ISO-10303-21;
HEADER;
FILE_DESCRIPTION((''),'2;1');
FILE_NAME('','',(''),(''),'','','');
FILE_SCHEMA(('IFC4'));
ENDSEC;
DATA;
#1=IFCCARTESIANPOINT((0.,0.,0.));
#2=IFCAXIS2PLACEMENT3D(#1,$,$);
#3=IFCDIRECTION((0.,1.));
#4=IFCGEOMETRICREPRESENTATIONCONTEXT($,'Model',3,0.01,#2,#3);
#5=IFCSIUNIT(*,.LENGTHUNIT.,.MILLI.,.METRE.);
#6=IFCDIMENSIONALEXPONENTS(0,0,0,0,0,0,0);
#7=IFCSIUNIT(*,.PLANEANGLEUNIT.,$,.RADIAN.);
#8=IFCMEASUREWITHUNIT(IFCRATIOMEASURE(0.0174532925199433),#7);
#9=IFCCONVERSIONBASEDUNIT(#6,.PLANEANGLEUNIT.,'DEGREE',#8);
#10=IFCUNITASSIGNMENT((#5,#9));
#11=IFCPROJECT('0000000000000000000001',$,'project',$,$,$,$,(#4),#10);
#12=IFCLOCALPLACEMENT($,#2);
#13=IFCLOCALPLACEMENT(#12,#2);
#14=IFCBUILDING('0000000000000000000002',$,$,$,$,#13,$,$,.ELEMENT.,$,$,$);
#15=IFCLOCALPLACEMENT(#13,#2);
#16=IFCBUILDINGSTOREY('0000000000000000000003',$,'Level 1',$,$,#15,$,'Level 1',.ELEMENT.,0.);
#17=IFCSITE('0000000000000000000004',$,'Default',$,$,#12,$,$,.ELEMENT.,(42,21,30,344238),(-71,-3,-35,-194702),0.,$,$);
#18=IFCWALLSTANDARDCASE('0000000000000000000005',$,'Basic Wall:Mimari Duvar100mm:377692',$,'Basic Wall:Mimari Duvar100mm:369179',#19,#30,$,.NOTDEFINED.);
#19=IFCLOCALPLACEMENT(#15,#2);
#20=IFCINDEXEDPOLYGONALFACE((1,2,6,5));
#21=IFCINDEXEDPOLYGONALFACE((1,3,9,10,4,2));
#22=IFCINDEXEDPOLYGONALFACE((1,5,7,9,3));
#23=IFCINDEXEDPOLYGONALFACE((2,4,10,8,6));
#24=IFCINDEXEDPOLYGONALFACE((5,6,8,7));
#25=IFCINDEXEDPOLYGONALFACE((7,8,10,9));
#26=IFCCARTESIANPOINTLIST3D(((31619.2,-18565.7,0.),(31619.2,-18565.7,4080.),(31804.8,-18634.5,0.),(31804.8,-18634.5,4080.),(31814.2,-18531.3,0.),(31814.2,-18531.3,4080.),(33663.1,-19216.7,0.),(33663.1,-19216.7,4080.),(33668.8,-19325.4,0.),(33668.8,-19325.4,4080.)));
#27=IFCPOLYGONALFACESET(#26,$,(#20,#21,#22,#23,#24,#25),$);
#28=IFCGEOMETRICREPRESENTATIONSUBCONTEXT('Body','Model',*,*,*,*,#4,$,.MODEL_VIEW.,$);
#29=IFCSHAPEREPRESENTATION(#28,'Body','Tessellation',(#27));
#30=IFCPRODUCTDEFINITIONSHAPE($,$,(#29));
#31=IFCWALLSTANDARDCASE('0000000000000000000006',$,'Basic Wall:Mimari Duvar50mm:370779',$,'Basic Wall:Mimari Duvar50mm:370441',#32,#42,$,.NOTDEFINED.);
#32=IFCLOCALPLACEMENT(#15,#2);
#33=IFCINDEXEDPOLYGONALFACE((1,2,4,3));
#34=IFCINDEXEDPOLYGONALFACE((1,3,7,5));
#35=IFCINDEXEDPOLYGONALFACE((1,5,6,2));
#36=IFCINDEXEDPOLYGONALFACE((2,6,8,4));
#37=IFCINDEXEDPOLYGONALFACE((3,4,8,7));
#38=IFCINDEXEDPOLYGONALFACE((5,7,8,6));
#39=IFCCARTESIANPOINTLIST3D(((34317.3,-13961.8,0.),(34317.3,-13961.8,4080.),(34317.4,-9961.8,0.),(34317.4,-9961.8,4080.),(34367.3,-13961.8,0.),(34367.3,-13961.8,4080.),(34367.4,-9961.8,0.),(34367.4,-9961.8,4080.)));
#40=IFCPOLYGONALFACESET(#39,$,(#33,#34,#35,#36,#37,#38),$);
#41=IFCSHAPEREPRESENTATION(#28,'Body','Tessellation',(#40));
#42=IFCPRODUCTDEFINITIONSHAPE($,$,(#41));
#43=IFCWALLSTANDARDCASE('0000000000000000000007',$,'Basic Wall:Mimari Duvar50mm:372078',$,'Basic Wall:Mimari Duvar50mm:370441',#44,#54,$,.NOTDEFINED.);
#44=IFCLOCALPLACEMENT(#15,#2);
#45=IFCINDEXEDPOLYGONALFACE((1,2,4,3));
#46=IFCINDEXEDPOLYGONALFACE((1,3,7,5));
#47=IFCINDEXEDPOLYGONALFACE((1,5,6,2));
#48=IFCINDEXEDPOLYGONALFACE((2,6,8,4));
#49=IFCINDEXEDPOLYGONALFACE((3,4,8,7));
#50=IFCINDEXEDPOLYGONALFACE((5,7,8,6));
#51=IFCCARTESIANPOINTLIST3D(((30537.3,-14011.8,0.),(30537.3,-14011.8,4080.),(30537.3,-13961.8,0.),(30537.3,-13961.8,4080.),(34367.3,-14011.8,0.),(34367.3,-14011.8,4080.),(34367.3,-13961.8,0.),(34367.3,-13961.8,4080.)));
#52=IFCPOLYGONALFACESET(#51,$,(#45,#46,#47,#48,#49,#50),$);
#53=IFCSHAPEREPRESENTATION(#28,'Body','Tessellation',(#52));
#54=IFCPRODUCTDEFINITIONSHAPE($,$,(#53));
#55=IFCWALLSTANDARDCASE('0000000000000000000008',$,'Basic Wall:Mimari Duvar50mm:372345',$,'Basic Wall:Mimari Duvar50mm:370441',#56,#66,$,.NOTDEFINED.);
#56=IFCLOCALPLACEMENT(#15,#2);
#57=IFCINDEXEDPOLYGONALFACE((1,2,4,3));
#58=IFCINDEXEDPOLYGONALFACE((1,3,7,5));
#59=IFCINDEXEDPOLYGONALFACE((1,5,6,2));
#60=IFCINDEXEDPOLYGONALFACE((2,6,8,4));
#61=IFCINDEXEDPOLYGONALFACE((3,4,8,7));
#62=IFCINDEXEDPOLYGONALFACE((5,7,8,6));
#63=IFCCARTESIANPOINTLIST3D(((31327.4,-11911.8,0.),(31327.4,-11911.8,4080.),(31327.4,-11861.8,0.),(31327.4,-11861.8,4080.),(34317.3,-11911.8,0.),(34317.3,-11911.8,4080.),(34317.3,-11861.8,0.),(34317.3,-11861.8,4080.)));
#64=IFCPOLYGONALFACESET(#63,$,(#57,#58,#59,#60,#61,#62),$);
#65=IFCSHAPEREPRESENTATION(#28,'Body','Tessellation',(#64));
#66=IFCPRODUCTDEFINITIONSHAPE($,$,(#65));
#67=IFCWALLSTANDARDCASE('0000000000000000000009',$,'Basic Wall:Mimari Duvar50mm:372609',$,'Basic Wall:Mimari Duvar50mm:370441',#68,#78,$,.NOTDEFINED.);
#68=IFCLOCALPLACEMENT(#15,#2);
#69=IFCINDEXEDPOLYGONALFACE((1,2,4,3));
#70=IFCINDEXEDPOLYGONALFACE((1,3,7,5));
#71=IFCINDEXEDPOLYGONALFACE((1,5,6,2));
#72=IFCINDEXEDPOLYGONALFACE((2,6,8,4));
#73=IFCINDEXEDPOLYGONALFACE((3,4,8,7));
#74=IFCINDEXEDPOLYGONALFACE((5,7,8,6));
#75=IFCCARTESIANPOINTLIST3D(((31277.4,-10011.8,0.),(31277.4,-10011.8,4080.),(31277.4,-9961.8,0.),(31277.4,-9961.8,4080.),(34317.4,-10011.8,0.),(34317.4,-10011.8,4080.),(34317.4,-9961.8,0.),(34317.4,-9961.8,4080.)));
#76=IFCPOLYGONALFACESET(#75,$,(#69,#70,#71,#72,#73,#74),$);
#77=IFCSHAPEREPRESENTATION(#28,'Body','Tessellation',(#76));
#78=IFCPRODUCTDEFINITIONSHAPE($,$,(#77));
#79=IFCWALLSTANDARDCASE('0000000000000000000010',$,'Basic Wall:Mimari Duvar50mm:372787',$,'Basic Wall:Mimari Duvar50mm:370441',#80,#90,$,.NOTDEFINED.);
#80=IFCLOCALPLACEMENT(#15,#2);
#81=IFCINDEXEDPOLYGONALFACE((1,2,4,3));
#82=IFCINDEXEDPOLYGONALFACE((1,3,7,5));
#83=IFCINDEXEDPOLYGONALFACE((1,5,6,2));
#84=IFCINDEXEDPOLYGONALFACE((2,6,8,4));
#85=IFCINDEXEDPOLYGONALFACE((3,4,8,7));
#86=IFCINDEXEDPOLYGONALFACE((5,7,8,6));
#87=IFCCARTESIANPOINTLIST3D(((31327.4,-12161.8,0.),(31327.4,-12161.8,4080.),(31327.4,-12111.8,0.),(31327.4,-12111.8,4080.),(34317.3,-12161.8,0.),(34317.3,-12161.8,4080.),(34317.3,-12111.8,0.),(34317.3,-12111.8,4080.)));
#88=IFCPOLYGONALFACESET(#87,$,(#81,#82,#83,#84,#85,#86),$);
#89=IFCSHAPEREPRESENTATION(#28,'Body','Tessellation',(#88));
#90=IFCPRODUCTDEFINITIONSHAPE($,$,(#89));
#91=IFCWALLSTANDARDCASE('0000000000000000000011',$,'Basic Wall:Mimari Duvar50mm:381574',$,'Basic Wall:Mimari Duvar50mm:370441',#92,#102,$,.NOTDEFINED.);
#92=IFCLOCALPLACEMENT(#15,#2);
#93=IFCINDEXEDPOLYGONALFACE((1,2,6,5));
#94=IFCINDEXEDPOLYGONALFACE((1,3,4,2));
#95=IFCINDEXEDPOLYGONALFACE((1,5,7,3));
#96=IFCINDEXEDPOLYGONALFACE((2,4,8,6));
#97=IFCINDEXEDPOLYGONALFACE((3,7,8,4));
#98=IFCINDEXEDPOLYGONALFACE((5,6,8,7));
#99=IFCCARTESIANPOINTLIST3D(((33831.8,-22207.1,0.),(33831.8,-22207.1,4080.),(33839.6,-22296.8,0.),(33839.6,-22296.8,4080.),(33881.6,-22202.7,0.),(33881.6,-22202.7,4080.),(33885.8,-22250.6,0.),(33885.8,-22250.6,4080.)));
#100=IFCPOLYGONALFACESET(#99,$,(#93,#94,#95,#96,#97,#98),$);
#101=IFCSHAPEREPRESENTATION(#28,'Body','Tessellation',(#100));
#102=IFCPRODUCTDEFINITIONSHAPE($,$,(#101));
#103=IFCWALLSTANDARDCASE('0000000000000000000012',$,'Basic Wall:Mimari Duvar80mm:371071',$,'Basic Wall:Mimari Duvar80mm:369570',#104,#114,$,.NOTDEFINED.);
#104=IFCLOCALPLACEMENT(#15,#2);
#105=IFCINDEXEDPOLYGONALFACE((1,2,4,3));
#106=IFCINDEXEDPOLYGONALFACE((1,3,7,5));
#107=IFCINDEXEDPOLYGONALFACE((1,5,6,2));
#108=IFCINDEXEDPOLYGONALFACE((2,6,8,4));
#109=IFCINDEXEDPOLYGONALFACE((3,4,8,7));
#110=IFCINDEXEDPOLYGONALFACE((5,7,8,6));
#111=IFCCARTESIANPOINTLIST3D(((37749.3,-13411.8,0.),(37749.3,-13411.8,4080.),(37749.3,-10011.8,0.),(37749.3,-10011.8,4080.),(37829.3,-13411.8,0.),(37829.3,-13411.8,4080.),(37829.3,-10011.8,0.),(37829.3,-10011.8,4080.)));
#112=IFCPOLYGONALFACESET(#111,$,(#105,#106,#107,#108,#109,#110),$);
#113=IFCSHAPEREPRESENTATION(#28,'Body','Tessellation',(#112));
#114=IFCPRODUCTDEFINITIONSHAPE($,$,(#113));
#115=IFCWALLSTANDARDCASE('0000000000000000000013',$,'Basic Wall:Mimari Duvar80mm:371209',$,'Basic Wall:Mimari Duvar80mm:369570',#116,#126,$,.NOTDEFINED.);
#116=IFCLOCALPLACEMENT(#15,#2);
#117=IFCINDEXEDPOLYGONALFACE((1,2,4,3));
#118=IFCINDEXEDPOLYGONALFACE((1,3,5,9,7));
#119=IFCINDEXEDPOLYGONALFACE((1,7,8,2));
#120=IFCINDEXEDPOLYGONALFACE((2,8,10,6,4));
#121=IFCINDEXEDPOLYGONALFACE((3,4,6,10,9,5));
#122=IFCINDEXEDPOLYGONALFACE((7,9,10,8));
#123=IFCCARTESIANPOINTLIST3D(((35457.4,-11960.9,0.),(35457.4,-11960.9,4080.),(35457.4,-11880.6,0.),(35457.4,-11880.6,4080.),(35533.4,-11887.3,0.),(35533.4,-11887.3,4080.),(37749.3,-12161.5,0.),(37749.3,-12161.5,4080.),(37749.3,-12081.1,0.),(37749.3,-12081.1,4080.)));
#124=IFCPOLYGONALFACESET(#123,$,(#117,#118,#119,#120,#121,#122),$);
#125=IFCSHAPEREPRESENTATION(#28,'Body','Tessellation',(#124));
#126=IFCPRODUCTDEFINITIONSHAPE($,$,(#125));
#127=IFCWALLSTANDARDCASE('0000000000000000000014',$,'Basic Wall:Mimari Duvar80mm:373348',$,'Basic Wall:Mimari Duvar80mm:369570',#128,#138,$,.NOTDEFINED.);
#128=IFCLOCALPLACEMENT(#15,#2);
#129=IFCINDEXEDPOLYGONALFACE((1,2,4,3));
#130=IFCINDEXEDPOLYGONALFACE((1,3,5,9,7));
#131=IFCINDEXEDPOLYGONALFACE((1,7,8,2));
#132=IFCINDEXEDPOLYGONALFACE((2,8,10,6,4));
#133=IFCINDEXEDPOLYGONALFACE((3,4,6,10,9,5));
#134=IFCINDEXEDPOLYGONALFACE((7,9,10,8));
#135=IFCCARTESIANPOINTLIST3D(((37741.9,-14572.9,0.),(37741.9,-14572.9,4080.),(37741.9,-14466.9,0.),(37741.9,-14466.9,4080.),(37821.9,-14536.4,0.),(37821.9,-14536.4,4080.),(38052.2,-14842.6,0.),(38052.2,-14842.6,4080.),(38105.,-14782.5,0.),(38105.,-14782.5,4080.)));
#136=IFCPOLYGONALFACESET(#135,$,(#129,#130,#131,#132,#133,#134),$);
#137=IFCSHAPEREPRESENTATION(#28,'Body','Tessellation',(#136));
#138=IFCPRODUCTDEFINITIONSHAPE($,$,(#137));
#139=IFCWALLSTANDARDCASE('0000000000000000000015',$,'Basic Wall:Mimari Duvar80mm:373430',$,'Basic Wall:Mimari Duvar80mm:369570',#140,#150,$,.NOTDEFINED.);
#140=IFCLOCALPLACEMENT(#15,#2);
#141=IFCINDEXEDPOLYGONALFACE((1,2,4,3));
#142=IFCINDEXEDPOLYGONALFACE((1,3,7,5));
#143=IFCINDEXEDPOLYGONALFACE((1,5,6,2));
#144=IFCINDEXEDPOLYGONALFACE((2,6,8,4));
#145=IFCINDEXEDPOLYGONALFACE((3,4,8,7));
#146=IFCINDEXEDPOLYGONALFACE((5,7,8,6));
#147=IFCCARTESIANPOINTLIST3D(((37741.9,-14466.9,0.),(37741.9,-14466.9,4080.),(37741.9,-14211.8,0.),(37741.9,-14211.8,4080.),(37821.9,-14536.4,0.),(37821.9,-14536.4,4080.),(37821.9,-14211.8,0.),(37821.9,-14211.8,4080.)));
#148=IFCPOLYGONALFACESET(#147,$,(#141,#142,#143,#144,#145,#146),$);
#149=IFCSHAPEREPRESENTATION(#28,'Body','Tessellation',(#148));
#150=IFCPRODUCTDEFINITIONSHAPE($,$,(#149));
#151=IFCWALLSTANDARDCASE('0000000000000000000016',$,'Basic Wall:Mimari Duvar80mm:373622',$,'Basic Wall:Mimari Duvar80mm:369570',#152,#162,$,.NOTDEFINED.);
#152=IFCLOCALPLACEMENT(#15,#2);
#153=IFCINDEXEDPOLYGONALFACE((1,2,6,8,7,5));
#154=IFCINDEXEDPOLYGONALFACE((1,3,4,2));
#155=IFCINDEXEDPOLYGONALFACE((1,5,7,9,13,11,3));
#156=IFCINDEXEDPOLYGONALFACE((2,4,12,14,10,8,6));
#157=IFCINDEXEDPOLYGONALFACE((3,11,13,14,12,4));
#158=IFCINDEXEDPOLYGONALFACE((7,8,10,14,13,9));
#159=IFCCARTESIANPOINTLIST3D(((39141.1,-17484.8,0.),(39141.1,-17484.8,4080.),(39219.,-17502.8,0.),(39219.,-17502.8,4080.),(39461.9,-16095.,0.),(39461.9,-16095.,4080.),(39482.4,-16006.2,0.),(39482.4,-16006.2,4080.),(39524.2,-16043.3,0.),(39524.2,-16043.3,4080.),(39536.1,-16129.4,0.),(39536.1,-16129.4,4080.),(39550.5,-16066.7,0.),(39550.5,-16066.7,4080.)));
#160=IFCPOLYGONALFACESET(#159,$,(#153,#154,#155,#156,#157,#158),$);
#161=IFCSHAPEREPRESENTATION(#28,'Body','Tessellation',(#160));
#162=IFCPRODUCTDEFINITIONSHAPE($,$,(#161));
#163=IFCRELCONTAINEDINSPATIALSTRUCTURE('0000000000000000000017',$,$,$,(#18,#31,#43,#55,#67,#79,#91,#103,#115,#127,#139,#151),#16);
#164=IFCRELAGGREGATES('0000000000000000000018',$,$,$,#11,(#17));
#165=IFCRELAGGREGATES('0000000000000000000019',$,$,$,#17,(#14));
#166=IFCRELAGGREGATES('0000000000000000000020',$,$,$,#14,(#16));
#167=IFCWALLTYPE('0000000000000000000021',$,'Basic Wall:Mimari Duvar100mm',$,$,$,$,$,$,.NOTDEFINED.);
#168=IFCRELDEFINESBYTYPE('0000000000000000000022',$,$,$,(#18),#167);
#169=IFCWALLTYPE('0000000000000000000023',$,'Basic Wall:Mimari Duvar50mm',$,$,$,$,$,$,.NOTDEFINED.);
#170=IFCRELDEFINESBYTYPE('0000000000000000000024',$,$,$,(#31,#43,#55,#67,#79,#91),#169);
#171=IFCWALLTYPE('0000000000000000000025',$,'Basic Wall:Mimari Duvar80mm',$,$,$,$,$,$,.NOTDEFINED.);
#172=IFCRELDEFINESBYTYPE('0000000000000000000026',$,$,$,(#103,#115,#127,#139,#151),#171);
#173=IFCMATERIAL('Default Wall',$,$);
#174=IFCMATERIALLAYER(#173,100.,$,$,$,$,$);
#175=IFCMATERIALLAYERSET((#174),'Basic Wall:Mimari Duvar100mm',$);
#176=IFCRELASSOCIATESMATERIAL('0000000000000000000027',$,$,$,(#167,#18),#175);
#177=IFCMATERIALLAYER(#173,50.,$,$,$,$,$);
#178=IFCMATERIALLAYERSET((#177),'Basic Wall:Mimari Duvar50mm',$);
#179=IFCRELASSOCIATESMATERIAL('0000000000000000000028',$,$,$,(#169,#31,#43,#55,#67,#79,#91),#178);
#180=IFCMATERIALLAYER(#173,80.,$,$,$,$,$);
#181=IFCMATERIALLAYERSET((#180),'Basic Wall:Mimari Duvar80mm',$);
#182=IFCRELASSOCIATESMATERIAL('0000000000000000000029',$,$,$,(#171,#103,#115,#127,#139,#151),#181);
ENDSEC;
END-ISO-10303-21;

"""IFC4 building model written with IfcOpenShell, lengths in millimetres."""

from ifc_helpers import new_model, entity, si_unit, converted_unit, direction, frame, frame_2d, origin, place, context, subcontext, project, spatial, polyline, rectangle, outline, extrude, material, layer, layer_set, layer_usage, type_object, element, save


model = new_model("IFC4")

# Units and contexts
model_context = context("Model", 3, precision=0.01, world=origin(), true_north=direction((0.0, 1.0)))
body_context = subcontext(model_context, "Body", "Model", "MODEL_VIEW")
ifc_project = project(units=[si_unit("LENGTHUNIT", "METRE", prefix="MILLI"), converted_unit("PLANEANGLEUNIT", "DEGREE", entity("IfcRatioMeasure", 0.0174532925199433), si_unit("PLANEANGLEUNIT", "RADIAN"), dimensions=[0, 0, 0, 0, 0, 0, 0])], contexts=[model_context])

# Site, building, storey
site_placement = place(None, origin())
site = spatial("IfcSite", under=ifc_project, at=site_placement, Name="Default", CompositionType="ELEMENT", RefLatitude=(42, 21, 30, 344238), RefLongitude=(-71, -3, -35, -194702), RefElevation=0.0)
building_placement = place(site_placement, origin())
building = spatial("IfcBuilding", under=site, at=building_placement, CompositionType="ELEMENT")
storey_placement = place(building_placement, origin())
storey = spatial("IfcBuildingStorey", under=building, at=storey_placement, Name="Level 1", LongName="Level 1", CompositionType="ELEMENT", Elevation=0.0)

# Walls
ifc_material_1 = material(Name="Default Wall")
ifc_layer_1 = layer(ifc_material_1, 100.0)
ifc_layer_set_1 = layer_set([ifc_layer_1], Name="Basic Wall:Mimari Duvar100mm")
ifc_layer_usage_1 = layer_usage(ifc_layer_set_1, "AXIS2", "NEGATIVE", 50.0)
wall_type_1 = type_object("IfcWallType", Name="Basic Wall:Mimari Duvar100mm", PredefinedType="NOTDEFINED", material=ifc_layer_set_1)
wall_1_placement = place(storey_placement, frame((33686.2, -19278.6, 0.0), z_axis=(0.0, 0.0, 1.0), x_axis=(-0.937659, 0.347558, 0.0)))
element("IfcWallStandardCase", 1, at=wall_1_placement, inside=storey, type_object=wall_type_1, material=ifc_layer_usage_1, Name="Basic Wall:Mimari Duvar100mm:377692", ObjectType="Basic Wall:Mimari Duvar100mm:369179", PredefinedType="NOTDEFINED", context=body_context, shape_type="SweptSolid", body=[
    extrude(outline(polyline([(2015.0, -50.0), (2185.9, 50.0), (1987.9, 50.0), (0.0, 50.0), (43.1, -50.0), (2015.0, -50.0)])), origin(), (0.0, 0.0, 1.0), 4080.0),
])
ifc_layer_2 = layer(ifc_material_1, 50.0)
ifc_layer_set_2 = layer_set([ifc_layer_2], Name="Basic Wall:Mimari Duvar50mm")
ifc_layer_usage_2 = layer_usage(ifc_layer_set_2, "AXIS2", "NEGATIVE", 25.0)
wall_type_2 = type_object("IfcWallType", Name="Basic Wall:Mimari Duvar50mm", PredefinedType="NOTDEFINED", material=ifc_layer_set_2)
wall_2_placement = place(storey_placement, frame((34342.3, -13961.8, 0.0), z_axis=(0.0, 0.0, 1.0), x_axis=(0.000009, 1.0, 0.0)))
element("IfcWallStandardCase", 2, at=wall_2_placement, inside=storey, type_object=wall_type_2, material=ifc_layer_usage_2, Name="Basic Wall:Mimari Duvar50mm:370779", ObjectType="Basic Wall:Mimari Duvar50mm:370441", PredefinedType="NOTDEFINED", context=body_context, shape_type="SweptSolid", body=[
    extrude(rectangle(XDim=4000.0, YDim=50.0, at=frame_2d((2000.0, 0.0), x_axis=(-1.0, 0.0))), origin(), (0.0, 0.0, 1.0), 4080.0),
])
ifc_layer_usage_3 = layer_usage(ifc_layer_set_2, "AXIS2", "NEGATIVE", 25.0)
wall_3_placement = place(storey_placement, frame((34367.3, -13986.8, 0.0), z_axis=(0.0, 0.0, 1.0), x_axis=(-1.0, 0.0, 0.0)))
element("IfcWallStandardCase", 3, at=wall_3_placement, inside=storey, type_object=wall_type_2, material=ifc_layer_usage_3, Name="Basic Wall:Mimari Duvar50mm:372078", ObjectType="Basic Wall:Mimari Duvar50mm:370441", PredefinedType="NOTDEFINED", context=body_context, shape_type="SweptSolid", body=[
    extrude(rectangle(XDim=3830.0, YDim=50.0, at=frame_2d((1915.0, 0.0), x_axis=(-1.0, 0.0))), origin(), (0.0, 0.0, 1.0), 4080.0),
])
ifc_layer_usage_4 = layer_usage(ifc_layer_set_2, "AXIS2", "NEGATIVE", 25.0)
wall_4_placement = place(storey_placement, frame((34317.3, -11886.8, 0.0), z_axis=(0.0, 0.0, 1.0), x_axis=(-1.0, 0.0, 0.0)))
element("IfcWallStandardCase", 4, at=wall_4_placement, inside=storey, type_object=wall_type_2, material=ifc_layer_usage_4, Name="Basic Wall:Mimari Duvar50mm:372345", ObjectType="Basic Wall:Mimari Duvar50mm:370441", PredefinedType="NOTDEFINED", context=body_context, shape_type="SweptSolid", body=[
    extrude(rectangle(XDim=2990.0, YDim=50.0, at=frame_2d((1495.0, 0.0), x_axis=(-1.0, 0.0))), origin(), (0.0, 0.0, 1.0), 4080.0),
])
ifc_layer_usage_5 = layer_usage(ifc_layer_set_2, "AXIS2", "NEGATIVE", 25.0)
wall_5_placement = place(storey_placement, frame((34317.4, -9986.8, 0.0), z_axis=(0.0, 0.0, 1.0), x_axis=(-1.0, 0.0, 0.0)))
element("IfcWallStandardCase", 5, at=wall_5_placement, inside=storey, type_object=wall_type_2, material=ifc_layer_usage_5, Name="Basic Wall:Mimari Duvar50mm:372609", ObjectType="Basic Wall:Mimari Duvar50mm:370441", PredefinedType="NOTDEFINED", context=body_context, shape_type="SweptSolid", body=[
    extrude(rectangle(XDim=3040.0, YDim=50.0, at=frame_2d((1520.0, 0.0), x_axis=(-1.0, 0.0))), origin(), (0.0, 0.0, 1.0), 4080.0),
])
ifc_layer_usage_6 = layer_usage(ifc_layer_set_2, "AXIS2", "NEGATIVE", 25.0)
wall_6_placement = place(storey_placement, frame((34317.3, -12136.8, 0.0), z_axis=(0.0, 0.0, 1.0), x_axis=(-1.0, 0.0, 0.0)))
element("IfcWallStandardCase", 6, at=wall_6_placement, inside=storey, type_object=wall_type_2, material=ifc_layer_usage_6, Name="Basic Wall:Mimari Duvar50mm:372787", ObjectType="Basic Wall:Mimari Duvar50mm:370441", PredefinedType="NOTDEFINED", context=body_context, shape_type="SweptSolid", body=[
    extrude(rectangle(XDim=2990.0, YDim=50.0, at=frame_2d((1495.0, 0.0), x_axis=(-1.0, 0.0))), origin(), (0.0, 0.0, 1.0), 4080.0),
])
ifc_layer_usage_7 = layer_usage(ifc_layer_set_2, "AXIS2", "NEGATIVE", 25.0)
wall_7_placement = place(storey_placement, frame((33864.6, -22294.6, 0.0), z_axis=(0.0, 0.0, 1.0), x_axis=(-0.087156, 0.996195, 0.0)))
element("IfcWallStandardCase", 7, at=wall_7_placement, inside=storey, type_object=wall_type_2, material=ifc_layer_usage_7, Name="Basic Wall:Mimari Duvar50mm:381574", ObjectType="Basic Wall:Mimari Duvar50mm:370441", PredefinedType="NOTDEFINED", context=body_context, shape_type="SweptSolid", body=[
    extrude(outline(polyline([(90.0, -25.0), (90.0, 25.0), (0.0, 25.0), (42.0, -25.0), (90.0, -25.0)])), origin(), (0.0, 0.0, 1.0), 4080.0),
])
ifc_layer_3 = layer(ifc_material_1, 80.0)
ifc_layer_set_3 = layer_set([ifc_layer_3], Name="Basic Wall:Mimari Duvar80mm")
ifc_layer_usage_8 = layer_usage(ifc_layer_set_3, "AXIS2", "NEGATIVE", 40.0)
wall_type_3 = type_object("IfcWallType", Name="Basic Wall:Mimari Duvar80mm", PredefinedType="NOTDEFINED", material=ifc_layer_set_3)
wall_8_placement = place(storey_placement, frame((37789.3, -13411.8, 0.0), z_axis=(0.0, 0.0, 1.0), x_axis=(0.0, 1.0, 0.0)))
element("IfcWallStandardCase", 8, at=wall_8_placement, inside=storey, type_object=wall_type_3, material=ifc_layer_usage_8, Name="Basic Wall:Mimari Duvar80mm:371071", ObjectType="Basic Wall:Mimari Duvar80mm:369570", PredefinedType="NOTDEFINED", context=body_context, shape_type="SweptSolid", body=[
    extrude(rectangle(XDim=3400.0, YDim=80.0, at=frame_2d((1700.0, 0.0), x_axis=(-1.0, 0.0))), origin(), (0.0, 0.0, 1.0), 4080.0),
])
ifc_layer_usage_9 = layer_usage(ifc_layer_set_3, "AXIS2", "NEGATIVE", 40.0)
wall_9_placement = place(storey_placement, frame((37752.8, -12121.6, 0.0), z_axis=(0.0, 0.0, 1.0), x_axis=(-0.996195, 0.087156, 0.0)))
element("IfcWallStandardCase", 9, at=wall_9_placement, inside=storey, type_object=wall_type_3, material=ifc_layer_usage_9, Name="Basic Wall:Mimari Duvar80mm:371209", ObjectType="Basic Wall:Mimari Duvar80mm:369570", PredefinedType="NOTDEFINED", context=body_context, shape_type="SweptSolid", body=[
    extrude(outline(polyline([(2307.6, -40.0), (2300.6, 40.0), (0.0, 40.0), (7.0, -40.0), (2231.3, -40.0), (2307.6, -40.0)])), origin(), (0.0, 0.0, 1.0), 4080.0),
])
ifc_layer_usage_10 = layer_usage(ifc_layer_set_3, "AXIS2", "NEGATIVE", 40.0)
wall_10_placement = place(storey_placement, frame((38078.7, -14812.6, 0.0), z_axis=(0.0, 0.0, 1.0), x_axis=(-0.75471, 0.656059, 0.0)))
element("IfcWallStandardCase", 10, at=wall_10_placement, inside=storey, type_object=wall_type_3, material=ifc_layer_usage_10, Name="Basic Wall:Mimari Duvar80mm:373348", ObjectType="Basic Wall:Mimari Duvar80mm:369570", PredefinedType="NOTDEFINED", context=body_context, shape_type="SweptSolid", body=[
    extrude(outline(polyline([(481.0, -40.0), (411.5, 40.0), (0.4, 40.0), (0.0, -40.0), (375.0, -40.0), (481.0, -40.0)])), origin(), (0.0, 0.0, 1.0), 4080.0),
])
ifc_layer_usage_11 = layer_usage(ifc_layer_set_3, "AXIS2", "NEGATIVE", 40.0)
wall_11_placement = place(storey_placement, frame((37781.9, -14536.4, 0.0), z_axis=(0.0, 0.0, 1.0), x_axis=(0.0, 1.0, 0.0)))
element("IfcWallStandardCase", 11, at=wall_11_placement, inside=storey, type_object=wall_type_3, material=ifc_layer_usage_11, Name="Basic Wall:Mimari Duvar80mm:373430", ObjectType="Basic Wall:Mimari Duvar80mm:369570", PredefinedType="NOTDEFINED", context=body_context, shape_type="SweptSolid", body=[
    extrude(outline(polyline([(324.7, -40.0), (324.7, 40.0), (69.5, 40.0), (0.0, -40.0), (324.7, -40.0)])), origin(), (0.0, 0.0, 1.0), 4080.0),
])
ifc_layer_usage_12 = layer_usage(ifc_layer_set_3, "AXIS2", "NEGATIVE", 40.0)
wall_12_placement = place(storey_placement, frame((39180.0, -17493.8, 0.0), z_axis=(0.0, 0.0, 1.0), x_axis=(0.224951, 0.97437, 0.0)))
element("IfcWallStandardCase", 12, at=wall_12_placement, inside=storey, type_object=wall_type_3, material=ifc_layer_usage_12, Name="Basic Wall:Mimari Duvar80mm:373622", ObjectType="Basic Wall:Mimari Duvar80mm:369570", PredefinedType="NOTDEFINED", context=body_context, shape_type="SweptSolid", body=[
    extrude(outline(polyline([(1473.8, -40.0), (1490.7, -9.1), (1517.4, 40.0), (1426.3, 40.0), (0.0, 40.0), (0.0, -40.0), (1409.5, -40.0), (1473.8, -40.0)])), origin(), (0.0, 0.0, 1.0), 4080.0),
])

save(model, "model.ifc")
